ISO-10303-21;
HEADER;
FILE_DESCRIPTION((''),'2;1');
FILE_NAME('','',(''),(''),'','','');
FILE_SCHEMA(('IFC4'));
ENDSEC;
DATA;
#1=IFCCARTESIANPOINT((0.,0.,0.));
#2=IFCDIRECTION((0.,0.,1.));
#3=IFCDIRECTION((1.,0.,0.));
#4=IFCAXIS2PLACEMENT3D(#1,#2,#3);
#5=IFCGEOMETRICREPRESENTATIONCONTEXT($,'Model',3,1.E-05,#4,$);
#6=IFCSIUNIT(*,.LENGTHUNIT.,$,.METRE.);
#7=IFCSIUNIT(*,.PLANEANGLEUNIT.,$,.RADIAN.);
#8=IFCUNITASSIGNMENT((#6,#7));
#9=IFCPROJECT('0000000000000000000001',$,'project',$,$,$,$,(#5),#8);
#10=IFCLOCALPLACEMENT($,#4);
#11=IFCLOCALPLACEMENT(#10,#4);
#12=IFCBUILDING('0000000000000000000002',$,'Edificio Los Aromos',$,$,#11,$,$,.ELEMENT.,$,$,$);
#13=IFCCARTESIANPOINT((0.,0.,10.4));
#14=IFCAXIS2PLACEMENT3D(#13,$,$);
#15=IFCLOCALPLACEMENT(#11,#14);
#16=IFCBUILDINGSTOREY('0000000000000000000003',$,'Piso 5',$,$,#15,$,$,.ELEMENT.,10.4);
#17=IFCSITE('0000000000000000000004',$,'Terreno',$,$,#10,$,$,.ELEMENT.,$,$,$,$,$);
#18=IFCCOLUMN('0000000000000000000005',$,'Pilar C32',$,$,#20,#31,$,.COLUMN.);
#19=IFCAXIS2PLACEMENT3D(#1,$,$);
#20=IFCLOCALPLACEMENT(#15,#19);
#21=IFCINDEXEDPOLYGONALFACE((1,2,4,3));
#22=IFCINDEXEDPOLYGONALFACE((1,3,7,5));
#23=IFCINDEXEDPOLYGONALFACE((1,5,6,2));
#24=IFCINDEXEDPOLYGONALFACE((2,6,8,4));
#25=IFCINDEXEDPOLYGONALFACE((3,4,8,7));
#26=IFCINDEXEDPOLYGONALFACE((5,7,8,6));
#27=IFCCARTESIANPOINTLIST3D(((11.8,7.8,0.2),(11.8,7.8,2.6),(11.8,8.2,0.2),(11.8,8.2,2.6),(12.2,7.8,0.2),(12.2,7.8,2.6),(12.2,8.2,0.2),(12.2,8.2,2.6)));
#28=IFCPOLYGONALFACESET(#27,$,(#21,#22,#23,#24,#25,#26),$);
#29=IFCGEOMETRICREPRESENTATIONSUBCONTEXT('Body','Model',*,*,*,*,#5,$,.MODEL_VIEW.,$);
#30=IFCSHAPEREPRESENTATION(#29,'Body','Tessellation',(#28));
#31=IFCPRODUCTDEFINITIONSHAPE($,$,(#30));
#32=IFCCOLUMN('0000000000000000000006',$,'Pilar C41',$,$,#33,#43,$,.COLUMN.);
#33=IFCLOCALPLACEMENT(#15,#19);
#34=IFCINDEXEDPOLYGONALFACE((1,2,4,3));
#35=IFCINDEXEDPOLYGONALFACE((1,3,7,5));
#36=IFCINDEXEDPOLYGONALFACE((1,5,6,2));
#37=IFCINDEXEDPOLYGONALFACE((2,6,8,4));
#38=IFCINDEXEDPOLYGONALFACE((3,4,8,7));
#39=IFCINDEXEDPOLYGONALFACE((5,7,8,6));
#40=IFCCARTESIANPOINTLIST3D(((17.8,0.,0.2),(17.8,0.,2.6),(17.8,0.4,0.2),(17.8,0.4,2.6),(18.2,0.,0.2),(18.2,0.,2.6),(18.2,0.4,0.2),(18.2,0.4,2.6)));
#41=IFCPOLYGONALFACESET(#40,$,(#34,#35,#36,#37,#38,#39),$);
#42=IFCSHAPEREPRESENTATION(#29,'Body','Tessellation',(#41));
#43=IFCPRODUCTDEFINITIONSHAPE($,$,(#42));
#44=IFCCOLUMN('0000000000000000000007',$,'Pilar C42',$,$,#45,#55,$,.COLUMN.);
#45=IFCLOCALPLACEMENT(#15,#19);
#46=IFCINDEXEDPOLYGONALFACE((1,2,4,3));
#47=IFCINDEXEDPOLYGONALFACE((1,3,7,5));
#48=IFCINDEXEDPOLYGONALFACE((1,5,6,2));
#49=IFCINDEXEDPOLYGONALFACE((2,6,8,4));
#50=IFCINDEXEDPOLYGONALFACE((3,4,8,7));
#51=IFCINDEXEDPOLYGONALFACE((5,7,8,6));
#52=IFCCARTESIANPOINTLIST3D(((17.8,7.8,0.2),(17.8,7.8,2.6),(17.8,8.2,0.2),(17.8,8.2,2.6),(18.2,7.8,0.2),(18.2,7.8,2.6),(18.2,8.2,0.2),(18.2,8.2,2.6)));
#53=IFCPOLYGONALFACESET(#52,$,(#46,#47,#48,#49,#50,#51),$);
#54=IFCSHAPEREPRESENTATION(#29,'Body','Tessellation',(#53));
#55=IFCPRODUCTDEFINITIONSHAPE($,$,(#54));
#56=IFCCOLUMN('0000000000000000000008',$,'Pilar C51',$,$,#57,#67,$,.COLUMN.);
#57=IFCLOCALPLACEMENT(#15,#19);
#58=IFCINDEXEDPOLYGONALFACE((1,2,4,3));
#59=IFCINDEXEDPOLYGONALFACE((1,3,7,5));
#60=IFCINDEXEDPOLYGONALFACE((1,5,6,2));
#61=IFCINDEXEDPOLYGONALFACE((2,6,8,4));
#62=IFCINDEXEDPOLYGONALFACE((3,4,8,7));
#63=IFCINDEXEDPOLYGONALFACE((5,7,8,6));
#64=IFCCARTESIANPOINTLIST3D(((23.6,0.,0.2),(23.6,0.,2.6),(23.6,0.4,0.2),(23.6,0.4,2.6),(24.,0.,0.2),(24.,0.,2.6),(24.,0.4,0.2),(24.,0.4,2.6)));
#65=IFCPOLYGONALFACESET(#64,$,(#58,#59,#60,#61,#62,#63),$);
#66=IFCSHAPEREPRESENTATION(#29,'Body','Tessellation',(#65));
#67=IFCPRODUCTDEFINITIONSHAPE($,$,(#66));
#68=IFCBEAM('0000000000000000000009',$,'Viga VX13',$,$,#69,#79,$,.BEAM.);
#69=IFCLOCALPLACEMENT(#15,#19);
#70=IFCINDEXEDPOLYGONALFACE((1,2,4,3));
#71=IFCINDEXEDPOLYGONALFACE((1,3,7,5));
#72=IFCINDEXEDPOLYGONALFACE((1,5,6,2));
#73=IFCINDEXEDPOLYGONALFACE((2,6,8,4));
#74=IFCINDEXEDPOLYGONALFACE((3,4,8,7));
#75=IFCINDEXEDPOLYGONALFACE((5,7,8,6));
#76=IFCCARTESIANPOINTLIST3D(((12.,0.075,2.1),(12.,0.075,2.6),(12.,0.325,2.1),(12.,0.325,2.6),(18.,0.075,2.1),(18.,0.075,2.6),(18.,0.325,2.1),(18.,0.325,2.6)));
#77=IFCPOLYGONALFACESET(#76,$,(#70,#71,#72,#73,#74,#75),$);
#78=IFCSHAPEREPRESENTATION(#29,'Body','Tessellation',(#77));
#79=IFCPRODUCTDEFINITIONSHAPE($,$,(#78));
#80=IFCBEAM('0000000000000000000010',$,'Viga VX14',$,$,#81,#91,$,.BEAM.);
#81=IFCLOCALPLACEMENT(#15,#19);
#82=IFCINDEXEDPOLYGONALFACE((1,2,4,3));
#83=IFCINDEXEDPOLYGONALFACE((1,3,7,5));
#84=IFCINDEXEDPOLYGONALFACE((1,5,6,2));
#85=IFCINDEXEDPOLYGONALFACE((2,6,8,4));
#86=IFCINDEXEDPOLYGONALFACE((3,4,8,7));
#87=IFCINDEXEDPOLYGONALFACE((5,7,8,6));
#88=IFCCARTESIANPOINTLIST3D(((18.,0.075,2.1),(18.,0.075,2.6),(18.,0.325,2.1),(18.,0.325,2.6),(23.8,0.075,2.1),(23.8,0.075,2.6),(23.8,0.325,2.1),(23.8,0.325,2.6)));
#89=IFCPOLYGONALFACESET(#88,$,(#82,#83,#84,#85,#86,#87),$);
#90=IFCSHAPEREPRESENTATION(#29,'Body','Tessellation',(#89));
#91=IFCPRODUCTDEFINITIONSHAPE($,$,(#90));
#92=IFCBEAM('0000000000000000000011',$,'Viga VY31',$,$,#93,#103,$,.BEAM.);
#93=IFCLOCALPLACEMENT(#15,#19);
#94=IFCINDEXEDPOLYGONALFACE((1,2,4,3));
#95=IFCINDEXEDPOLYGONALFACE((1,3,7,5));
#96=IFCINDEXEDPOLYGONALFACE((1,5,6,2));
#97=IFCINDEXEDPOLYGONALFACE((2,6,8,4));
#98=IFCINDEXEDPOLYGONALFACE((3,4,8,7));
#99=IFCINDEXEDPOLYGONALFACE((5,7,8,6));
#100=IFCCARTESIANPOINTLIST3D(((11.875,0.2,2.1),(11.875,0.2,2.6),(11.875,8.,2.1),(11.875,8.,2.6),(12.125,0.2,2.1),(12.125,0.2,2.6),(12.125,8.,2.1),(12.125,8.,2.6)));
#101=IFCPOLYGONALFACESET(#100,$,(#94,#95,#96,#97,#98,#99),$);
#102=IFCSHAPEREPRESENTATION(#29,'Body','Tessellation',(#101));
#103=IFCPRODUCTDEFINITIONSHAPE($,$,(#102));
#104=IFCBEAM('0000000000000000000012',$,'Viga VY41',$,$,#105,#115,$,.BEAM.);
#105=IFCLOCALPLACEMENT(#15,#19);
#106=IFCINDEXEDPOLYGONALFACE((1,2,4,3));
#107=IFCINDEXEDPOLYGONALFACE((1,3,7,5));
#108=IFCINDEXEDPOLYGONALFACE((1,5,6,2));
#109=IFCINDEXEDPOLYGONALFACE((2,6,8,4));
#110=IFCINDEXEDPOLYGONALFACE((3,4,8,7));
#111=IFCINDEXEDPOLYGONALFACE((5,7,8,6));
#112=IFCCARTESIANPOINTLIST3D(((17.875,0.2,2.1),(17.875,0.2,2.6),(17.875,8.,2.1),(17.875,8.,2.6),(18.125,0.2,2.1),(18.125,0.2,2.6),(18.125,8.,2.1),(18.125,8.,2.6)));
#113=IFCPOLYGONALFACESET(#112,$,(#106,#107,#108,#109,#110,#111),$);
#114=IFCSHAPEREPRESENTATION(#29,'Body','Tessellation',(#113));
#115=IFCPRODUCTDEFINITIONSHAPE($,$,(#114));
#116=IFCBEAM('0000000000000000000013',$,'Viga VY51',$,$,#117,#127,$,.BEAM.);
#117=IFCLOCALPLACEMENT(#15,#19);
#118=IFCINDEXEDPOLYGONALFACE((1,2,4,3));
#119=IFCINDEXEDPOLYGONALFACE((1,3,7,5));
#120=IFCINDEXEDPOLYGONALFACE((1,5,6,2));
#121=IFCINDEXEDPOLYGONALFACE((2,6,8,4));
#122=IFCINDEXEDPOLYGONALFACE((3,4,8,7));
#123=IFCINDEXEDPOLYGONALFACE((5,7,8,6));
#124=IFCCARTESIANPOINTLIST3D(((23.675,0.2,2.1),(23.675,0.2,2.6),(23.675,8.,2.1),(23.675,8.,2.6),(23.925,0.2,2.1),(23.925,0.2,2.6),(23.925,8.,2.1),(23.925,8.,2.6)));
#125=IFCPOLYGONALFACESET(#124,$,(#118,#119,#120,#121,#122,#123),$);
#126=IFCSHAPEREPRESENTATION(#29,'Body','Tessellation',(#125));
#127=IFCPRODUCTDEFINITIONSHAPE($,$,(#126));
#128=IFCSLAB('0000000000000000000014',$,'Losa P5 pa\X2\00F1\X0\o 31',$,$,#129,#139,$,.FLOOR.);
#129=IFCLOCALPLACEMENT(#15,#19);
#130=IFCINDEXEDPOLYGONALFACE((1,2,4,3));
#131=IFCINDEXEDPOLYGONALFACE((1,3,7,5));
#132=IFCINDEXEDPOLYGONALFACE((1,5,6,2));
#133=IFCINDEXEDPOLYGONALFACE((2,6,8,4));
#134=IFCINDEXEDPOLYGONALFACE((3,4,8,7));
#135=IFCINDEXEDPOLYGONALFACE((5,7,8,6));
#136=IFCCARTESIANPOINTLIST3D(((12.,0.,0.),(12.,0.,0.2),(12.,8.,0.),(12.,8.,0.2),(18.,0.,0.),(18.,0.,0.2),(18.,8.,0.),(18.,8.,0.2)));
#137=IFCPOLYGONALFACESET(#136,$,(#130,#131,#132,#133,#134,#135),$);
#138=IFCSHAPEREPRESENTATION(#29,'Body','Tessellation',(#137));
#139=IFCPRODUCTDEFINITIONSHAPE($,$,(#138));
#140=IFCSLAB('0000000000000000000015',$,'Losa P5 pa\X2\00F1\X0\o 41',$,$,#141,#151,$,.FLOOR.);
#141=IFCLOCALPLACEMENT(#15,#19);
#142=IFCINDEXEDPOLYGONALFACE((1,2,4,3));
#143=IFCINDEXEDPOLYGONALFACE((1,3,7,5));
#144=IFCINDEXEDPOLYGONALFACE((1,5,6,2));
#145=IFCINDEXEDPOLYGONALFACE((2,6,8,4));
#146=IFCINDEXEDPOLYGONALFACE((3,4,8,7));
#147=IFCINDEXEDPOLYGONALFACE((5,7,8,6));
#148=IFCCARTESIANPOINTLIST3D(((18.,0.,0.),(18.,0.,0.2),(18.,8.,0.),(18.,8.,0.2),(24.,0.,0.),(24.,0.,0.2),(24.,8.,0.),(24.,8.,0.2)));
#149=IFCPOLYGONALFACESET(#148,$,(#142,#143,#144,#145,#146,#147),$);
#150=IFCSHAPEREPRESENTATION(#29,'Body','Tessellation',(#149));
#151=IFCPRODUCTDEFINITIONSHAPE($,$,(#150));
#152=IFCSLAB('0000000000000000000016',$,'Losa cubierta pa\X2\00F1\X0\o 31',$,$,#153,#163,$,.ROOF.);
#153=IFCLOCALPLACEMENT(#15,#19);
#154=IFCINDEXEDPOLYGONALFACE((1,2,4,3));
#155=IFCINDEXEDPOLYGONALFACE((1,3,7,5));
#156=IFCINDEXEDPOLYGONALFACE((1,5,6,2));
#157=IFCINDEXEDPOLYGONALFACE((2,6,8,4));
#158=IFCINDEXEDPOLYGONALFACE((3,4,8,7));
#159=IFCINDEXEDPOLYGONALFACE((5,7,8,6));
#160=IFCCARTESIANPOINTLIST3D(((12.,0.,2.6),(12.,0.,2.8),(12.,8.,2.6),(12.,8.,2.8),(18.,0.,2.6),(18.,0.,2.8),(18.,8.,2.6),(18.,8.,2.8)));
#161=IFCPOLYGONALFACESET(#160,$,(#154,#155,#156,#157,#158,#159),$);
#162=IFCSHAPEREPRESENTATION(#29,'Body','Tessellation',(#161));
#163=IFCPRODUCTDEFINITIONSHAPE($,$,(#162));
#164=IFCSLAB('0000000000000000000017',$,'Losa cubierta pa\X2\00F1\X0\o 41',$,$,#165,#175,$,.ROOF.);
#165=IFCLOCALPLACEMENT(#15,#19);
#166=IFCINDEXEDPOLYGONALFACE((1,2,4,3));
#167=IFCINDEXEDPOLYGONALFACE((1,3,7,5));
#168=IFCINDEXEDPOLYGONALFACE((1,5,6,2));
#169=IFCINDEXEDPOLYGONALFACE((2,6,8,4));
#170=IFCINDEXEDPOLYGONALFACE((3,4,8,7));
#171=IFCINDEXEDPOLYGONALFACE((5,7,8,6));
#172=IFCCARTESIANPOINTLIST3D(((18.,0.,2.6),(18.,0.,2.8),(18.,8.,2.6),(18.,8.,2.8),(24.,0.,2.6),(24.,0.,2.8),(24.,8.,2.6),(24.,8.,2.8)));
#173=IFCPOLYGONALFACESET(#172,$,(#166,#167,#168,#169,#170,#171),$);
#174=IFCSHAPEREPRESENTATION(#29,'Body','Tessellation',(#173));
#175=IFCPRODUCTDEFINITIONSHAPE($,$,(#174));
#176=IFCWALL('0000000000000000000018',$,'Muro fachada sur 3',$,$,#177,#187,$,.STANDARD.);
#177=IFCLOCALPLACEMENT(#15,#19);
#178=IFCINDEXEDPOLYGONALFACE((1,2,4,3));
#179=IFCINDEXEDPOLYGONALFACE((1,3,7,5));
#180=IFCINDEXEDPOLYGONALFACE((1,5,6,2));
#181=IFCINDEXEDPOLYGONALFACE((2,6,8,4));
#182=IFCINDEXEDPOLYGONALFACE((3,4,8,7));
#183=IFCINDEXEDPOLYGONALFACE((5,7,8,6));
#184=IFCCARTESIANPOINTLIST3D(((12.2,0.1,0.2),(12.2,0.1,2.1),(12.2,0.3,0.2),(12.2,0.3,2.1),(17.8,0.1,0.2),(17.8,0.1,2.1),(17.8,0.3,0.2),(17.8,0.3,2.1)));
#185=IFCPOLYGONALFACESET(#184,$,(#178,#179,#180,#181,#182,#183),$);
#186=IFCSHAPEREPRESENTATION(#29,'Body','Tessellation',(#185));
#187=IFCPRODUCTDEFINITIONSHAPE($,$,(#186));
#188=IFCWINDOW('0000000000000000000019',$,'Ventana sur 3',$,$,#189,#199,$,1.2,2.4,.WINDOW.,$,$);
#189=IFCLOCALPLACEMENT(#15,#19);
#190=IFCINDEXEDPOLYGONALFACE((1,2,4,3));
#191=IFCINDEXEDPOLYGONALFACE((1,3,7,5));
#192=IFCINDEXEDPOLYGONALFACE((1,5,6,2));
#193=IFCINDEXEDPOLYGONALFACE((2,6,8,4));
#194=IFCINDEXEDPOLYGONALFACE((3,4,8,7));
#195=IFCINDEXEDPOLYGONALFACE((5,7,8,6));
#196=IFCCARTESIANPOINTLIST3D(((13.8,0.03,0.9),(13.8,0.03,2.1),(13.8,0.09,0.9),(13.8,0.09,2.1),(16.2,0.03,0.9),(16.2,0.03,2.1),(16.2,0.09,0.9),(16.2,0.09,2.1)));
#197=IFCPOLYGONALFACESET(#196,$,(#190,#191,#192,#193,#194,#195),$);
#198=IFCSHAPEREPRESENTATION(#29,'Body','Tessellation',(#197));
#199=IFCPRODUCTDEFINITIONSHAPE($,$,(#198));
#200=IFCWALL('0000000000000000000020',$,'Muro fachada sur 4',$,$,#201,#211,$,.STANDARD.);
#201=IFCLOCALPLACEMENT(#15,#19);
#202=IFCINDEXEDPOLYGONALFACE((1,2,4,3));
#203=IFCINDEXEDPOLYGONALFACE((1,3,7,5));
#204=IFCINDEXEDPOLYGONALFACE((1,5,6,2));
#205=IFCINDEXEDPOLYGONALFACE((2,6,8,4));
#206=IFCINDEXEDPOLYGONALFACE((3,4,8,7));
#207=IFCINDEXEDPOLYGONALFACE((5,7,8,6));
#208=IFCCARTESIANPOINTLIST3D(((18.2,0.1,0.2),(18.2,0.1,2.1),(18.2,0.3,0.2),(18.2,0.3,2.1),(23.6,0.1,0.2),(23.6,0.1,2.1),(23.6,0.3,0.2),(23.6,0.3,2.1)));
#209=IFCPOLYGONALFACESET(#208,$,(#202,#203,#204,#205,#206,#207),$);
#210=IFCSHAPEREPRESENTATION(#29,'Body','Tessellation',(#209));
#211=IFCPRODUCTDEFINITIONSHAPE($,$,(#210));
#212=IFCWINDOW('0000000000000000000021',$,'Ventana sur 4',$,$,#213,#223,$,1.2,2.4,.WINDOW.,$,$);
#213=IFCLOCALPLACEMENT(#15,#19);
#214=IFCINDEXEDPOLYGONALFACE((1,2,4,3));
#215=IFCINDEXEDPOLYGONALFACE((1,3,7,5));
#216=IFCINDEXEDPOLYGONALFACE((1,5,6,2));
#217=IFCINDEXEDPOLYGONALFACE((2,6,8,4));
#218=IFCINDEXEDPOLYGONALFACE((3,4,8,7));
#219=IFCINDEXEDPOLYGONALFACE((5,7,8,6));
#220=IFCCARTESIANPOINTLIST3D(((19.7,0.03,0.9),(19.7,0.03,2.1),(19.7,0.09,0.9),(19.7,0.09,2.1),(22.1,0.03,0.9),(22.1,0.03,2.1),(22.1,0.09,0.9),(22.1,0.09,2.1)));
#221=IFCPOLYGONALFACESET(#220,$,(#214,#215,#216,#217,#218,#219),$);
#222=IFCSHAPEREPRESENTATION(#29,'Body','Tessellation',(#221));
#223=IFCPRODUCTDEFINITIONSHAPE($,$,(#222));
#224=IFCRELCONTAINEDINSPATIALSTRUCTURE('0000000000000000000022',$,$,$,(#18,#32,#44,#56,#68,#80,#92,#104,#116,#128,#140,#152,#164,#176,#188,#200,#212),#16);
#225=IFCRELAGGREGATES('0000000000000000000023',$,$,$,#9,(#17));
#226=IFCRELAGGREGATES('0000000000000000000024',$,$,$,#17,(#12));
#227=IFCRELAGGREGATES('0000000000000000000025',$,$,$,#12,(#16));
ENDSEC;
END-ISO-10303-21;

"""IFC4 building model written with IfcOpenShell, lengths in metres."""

from ifc_helpers import new_model, si_unit, frame, frame_2d, origin_with_axes, place, context, subcontext, project, spatial, rectangle, extrude, element, save


model = new_model("IFC4")

# Units and contexts
model_context = context("Model", 3, precision=1e-05, world=origin_with_axes())
body_context = subcontext(model_context, "Body", "Model", "MODEL_VIEW")
ifc_project = project(units=[si_unit("LENGTHUNIT", "METRE"), si_unit("PLANEANGLEUNIT", "RADIAN")], contexts=[model_context])

# Site, building, storey
site_placement = place(None, origin_with_axes())
site = spatial("IfcSite", under=ifc_project, at=site_placement, Name="Terreno", CompositionType="ELEMENT")
building_placement = place(site_placement, origin_with_axes())
building = spatial("IfcBuilding", under=site, at=building_placement, Name="Edificio Los Aromos", CompositionType="ELEMENT")
storey_placement = place(building_placement, frame((0.0, 0.0, 10.4)))
storey = spatial("IfcBuildingStorey", under=building, at=storey_placement, Name="Piso 5", CompositionType="ELEMENT", Elevation=10.4)

# Columns
for number, where, name in (
    (1, (11.8, 7.8, 0.2), "Pilar C32"),
    (2, (17.8, 0.0, 0.2), "Pilar C41"),
    (3, (17.8, 7.8, 0.2), "Pilar C42"),
    (4, (23.6, 0.0, 0.2), "Pilar C51"),
):
    element("IfcColumn", number, at=place(storey_placement, frame(where)), inside=storey, Name=name, PredefinedType="COLUMN", context=body_context, shape_type="SweptSolid", body=[
        extrude(rectangle(XDim=0.4, YDim=0.4, at=frame_2d((0.2, 0.2))), origin_with_axes(), (0.0, 0.0, 1.0), 2.4),
    ])

# Beams
beam_1_placement = place(storey_placement, frame((12.0, 0.075, 2.1)))
element("IfcBeam", 5, at=beam_1_placement, inside=storey, Name="Viga VX13", PredefinedType="BEAM", context=body_context, shape_type="SweptSolid", body=[
    extrude(rectangle(XDim=6.0, YDim=0.25, at=frame_2d((3.0, 0.125))), origin_with_axes(), (0.0, 0.0, 1.0), 0.5),
])
beam_2_placement = place(storey_placement, frame((18.0, 0.075, 2.1)))
element("IfcBeam", 6, at=beam_2_placement, inside=storey, Name="Viga VX14", PredefinedType="BEAM", context=body_context, shape_type="SweptSolid", body=[
    extrude(rectangle(XDim=5.8, YDim=0.25, at=frame_2d((2.9, 0.125))), origin_with_axes(), (0.0, 0.0, 1.0), 0.5),
])
for number, where, name in (
    (7, (11.875, 0.2, 2.1), "Viga VY31"),
    (8, (17.875, 0.2, 2.1), "Viga VY41"),
    (9, (23.675, 0.2, 2.1), "Viga VY51"),
):
    element("IfcBeam", number, at=place(storey_placement, frame(where)), inside=storey, Name=name, PredefinedType="BEAM", context=body_context, shape_type="SweptSolid", body=[
        extrude(rectangle(XDim=0.25, YDim=7.8, at=frame_2d((0.125, 3.9))), origin_with_axes(), (0.0, 0.0, 1.0), 0.5),
    ])

# Slabs
for number, where, name in (
    (10, (12.0, 0.0, 0.0), "Losa P5 paño 31"),
    (11, (18.0, 0.0, 0.0), "Losa P5 paño 41"),
):
    element("IfcSlab", number, at=place(storey_placement, frame(where)), inside=storey, Name=name, PredefinedType="FLOOR", context=body_context, shape_type="SweptSolid", body=[
        extrude(rectangle(XDim=6.0, YDim=8.0, at=frame_2d((3.0, 4.0))), origin_with_axes(), (0.0, 0.0, 1.0), 0.2),
    ])
for number, where, name in (
    (12, (12.0, 0.0, 2.6), "Losa cubierta paño 31"),
    (13, (18.0, 0.0, 2.6), "Losa cubierta paño 41"),
):
    element("IfcSlab", number, at=place(storey_placement, frame(where)), inside=storey, Name=name, PredefinedType="ROOF", context=body_context, shape_type="SweptSolid", body=[
        extrude(rectangle(XDim=6.0, YDim=8.0, at=frame_2d((3.0, 4.0))), origin_with_axes(), (0.0, 0.0, 1.0), 0.2),
    ])

# Wall
wall_1_placement = place(storey_placement, frame((12.2, 0.1, 0.2)))
element("IfcWall", 14, at=wall_1_placement, inside=storey, Name="Muro fachada sur 3", PredefinedType="STANDARD", context=body_context, shape_type="SweptSolid", body=[
    extrude(rectangle(XDim=5.6, YDim=0.2, at=frame_2d((2.8, 0.1))), origin_with_axes(), (0.0, 0.0, 1.0), 1.9),
])

# Window
window_1_placement = place(storey_placement, frame((13.8, 0.03, 0.9)))
element("IfcWindow", 15, at=window_1_placement, inside=storey, Name="Ventana sur 3", OverallHeight=1.2, OverallWidth=2.4, PredefinedType="WINDOW", context=body_context, shape_type="SweptSolid", body=[
    extrude(rectangle(XDim=2.4, YDim=0.06, at=frame_2d((1.2, 0.03))), origin_with_axes(), (0.0, 0.0, 1.0), 1.2),
])

# Wall
wall_2_placement = place(storey_placement, frame((18.2, 0.1, 0.2)))
element("IfcWall", 16, at=wall_2_placement, inside=storey, Name="Muro fachada sur 4", PredefinedType="STANDARD", context=body_context, shape_type="SweptSolid", body=[
    extrude(rectangle(XDim=5.4, YDim=0.2, at=frame_2d((2.7, 0.1))), origin_with_axes(), (0.0, 0.0, 1.0), 1.9),
])

# Window
window_2_placement = place(storey_placement, frame((19.7, 0.03, 0.9)))
element("IfcWindow", 17, at=window_2_placement, inside=storey, Name="Ventana sur 4", OverallHeight=1.2, OverallWidth=2.4, PredefinedType="WINDOW", context=body_context, shape_type="SweptSolid", body=[
    extrude(rectangle(XDim=2.4, YDim=0.06, at=frame_2d((1.2, 0.03))), origin_with_axes(), (0.0, 0.0, 1.0), 1.2),
])

save(model, "model.ifc")
